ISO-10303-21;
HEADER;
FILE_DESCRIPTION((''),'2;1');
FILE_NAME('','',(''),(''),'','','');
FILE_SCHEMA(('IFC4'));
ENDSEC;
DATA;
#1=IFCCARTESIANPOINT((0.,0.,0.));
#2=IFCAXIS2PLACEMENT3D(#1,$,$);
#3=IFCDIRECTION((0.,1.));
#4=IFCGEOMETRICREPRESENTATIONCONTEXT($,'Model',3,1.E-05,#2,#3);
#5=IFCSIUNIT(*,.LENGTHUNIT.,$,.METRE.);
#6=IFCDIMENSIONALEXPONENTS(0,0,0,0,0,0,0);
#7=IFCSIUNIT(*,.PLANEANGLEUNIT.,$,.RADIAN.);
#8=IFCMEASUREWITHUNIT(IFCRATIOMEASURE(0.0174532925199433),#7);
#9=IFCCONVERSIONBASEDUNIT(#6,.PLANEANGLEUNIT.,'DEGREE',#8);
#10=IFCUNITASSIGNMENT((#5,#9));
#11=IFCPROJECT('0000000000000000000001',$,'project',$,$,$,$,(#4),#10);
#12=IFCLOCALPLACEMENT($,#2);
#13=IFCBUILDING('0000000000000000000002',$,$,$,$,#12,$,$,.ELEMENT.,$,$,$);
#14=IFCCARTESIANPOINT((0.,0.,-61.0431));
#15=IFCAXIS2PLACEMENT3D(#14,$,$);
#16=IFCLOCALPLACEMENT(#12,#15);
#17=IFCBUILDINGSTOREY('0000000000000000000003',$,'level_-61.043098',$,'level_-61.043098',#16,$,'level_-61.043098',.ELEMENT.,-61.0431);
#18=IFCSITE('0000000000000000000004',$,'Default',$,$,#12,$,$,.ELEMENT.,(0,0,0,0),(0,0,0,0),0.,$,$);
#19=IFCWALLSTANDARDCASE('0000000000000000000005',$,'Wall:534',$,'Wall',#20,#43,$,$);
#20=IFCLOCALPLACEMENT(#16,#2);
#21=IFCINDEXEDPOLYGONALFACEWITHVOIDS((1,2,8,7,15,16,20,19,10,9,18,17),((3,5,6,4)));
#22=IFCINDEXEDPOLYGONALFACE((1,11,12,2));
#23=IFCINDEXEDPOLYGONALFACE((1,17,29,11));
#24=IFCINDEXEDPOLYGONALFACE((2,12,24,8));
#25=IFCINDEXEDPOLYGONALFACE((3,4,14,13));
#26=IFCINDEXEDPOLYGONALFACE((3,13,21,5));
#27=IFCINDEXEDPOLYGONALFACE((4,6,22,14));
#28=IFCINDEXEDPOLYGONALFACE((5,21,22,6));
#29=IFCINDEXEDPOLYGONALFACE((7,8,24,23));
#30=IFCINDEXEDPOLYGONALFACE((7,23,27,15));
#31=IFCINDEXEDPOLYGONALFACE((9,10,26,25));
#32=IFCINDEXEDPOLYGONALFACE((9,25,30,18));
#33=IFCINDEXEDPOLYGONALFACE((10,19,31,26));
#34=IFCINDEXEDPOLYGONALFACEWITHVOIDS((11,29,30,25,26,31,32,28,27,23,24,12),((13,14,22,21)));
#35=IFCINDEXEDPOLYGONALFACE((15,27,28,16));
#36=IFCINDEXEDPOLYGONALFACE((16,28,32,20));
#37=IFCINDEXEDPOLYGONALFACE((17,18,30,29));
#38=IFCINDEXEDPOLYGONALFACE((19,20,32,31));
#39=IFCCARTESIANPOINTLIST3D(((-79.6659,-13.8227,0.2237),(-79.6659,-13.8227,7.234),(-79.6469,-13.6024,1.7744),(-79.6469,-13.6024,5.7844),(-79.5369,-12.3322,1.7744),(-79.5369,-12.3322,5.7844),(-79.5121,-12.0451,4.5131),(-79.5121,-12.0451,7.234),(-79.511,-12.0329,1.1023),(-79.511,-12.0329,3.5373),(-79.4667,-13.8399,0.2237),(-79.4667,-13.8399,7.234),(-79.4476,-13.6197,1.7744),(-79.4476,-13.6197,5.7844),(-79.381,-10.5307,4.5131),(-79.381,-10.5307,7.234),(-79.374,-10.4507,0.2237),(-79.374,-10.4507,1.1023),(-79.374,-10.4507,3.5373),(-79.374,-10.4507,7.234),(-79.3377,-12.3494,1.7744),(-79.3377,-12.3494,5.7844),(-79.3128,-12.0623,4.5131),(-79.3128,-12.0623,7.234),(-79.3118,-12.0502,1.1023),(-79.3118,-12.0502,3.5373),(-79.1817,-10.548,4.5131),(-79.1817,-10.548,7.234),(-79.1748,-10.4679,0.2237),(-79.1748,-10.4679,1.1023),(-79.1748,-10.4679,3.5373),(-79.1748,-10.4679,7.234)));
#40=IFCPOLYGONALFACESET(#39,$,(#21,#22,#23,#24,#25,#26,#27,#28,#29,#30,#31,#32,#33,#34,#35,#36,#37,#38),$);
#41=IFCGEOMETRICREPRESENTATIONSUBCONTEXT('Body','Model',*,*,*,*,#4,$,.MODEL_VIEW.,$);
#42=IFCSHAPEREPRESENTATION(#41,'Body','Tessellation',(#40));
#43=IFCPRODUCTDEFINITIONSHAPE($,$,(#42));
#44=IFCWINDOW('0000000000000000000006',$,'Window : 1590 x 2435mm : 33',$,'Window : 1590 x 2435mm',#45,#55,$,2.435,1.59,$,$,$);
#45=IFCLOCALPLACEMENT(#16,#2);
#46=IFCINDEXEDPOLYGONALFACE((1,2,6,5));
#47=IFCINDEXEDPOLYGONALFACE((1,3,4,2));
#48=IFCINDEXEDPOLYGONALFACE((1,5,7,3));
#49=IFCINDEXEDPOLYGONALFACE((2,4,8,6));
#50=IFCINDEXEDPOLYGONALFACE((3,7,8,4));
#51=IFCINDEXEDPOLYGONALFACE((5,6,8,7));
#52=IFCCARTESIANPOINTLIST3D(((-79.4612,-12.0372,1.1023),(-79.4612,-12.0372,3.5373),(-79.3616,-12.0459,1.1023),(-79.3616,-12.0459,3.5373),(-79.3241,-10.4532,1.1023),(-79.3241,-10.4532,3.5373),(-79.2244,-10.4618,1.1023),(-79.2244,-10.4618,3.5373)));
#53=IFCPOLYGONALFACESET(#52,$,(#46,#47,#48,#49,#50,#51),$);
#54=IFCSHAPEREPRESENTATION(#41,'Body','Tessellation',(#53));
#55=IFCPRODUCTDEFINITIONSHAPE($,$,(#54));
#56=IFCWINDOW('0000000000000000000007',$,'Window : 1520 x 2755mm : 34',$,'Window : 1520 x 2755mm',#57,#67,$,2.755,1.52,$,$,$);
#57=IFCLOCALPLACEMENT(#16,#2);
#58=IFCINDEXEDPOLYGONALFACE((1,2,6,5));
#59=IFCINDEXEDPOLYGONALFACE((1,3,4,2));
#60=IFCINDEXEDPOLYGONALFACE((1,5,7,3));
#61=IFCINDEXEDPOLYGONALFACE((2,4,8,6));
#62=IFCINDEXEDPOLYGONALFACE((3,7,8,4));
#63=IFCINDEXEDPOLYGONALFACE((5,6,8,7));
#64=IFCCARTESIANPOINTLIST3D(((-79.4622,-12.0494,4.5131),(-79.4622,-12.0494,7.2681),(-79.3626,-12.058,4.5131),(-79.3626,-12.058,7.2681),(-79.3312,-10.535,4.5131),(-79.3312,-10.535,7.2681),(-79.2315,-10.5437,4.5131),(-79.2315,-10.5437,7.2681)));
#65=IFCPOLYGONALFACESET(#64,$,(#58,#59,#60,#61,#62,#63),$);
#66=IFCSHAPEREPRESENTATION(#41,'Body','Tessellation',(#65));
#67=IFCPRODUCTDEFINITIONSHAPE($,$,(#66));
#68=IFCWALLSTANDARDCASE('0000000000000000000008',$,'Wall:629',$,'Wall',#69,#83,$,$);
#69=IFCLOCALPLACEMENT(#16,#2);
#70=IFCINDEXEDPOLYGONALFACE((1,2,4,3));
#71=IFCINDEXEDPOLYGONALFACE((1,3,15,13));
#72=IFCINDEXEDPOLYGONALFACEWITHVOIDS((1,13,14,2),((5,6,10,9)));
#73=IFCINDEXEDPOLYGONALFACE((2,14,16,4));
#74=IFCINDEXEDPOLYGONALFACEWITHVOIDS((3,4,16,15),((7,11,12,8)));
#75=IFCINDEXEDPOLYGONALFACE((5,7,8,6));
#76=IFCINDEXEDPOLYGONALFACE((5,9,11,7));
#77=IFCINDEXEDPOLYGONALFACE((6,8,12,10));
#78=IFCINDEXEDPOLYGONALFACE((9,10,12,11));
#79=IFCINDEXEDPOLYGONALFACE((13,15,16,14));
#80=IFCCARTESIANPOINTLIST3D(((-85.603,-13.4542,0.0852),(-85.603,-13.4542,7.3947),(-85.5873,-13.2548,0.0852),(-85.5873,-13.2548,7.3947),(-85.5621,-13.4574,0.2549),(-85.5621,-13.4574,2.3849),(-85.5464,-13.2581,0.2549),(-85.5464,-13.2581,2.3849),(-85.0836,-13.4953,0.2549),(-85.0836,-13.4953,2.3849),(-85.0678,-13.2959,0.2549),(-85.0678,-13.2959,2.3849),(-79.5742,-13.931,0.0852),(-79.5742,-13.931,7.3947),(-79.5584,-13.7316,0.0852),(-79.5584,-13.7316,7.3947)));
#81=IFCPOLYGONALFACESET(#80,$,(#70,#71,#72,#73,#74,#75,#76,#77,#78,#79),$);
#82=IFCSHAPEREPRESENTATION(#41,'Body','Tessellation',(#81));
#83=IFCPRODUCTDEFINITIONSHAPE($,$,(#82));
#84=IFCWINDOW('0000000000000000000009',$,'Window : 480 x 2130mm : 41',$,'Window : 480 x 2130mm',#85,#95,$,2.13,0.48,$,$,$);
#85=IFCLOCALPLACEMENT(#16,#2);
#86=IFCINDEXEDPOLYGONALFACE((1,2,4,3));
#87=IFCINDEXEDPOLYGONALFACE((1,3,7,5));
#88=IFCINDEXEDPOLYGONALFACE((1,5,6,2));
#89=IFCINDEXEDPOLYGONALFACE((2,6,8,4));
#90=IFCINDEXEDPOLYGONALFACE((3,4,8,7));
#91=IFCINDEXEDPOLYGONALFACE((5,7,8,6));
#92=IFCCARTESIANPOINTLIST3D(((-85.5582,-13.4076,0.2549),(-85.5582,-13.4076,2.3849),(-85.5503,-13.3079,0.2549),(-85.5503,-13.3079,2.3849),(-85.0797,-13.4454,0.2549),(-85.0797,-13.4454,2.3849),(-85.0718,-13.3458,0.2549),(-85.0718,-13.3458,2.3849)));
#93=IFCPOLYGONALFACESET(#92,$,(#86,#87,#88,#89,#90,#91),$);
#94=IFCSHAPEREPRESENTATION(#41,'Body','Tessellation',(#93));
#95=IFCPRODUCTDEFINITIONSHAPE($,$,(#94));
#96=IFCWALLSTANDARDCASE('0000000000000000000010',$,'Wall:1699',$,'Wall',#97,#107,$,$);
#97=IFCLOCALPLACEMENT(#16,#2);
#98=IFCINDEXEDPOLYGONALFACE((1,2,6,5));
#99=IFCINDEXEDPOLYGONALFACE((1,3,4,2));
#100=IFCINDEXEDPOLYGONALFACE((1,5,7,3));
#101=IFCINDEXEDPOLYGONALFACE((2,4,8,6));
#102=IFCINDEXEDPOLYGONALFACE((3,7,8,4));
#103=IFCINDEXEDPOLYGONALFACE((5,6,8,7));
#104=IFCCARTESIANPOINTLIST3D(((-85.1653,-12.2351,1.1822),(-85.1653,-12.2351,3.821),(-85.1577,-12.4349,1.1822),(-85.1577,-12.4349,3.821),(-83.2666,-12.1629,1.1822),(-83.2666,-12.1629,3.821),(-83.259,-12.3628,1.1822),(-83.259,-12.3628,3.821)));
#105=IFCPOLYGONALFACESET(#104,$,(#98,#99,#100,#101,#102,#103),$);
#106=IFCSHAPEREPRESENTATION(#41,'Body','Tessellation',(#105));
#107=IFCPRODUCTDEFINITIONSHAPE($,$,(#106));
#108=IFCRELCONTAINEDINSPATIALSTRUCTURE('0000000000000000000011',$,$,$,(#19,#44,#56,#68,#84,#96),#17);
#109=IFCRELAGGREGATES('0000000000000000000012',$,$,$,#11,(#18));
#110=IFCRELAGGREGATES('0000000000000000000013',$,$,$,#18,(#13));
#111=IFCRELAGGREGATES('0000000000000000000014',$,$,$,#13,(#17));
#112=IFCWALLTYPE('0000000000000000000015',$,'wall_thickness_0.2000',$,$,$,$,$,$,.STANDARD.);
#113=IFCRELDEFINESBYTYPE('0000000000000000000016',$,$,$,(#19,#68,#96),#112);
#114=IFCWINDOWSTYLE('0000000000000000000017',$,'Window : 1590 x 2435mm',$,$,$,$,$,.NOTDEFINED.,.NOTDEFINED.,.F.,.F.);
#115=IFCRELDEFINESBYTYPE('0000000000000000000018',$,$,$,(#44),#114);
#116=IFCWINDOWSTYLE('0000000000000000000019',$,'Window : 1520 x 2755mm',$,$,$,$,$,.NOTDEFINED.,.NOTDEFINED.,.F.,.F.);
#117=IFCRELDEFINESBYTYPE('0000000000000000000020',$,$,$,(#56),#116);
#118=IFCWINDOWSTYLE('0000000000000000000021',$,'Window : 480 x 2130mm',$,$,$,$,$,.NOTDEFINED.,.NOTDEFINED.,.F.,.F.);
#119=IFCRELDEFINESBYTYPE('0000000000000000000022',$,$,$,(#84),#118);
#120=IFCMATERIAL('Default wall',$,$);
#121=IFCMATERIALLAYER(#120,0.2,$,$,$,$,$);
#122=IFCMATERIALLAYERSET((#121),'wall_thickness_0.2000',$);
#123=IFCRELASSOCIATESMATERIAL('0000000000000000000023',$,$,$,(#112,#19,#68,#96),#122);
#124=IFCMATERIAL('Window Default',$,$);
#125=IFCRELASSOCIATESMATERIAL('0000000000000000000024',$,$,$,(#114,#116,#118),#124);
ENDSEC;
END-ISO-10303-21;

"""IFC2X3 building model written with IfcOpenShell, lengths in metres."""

from ifc_helpers import new_model, entity, si_unit, converted_unit, direction, frame, frame_2d, origin, origin_2d_with_axis, place, context, subcontext, project, spatial, polyline, rectangle, outline, extrude, source, transform, mapped, material, layer, layer_set, layer_usage, type_object, type_shapes, element, fill, save


model = new_model("IFC2X3")

# Units and contexts
model_context = context("Model", 3, precision=1e-05, world=origin(), true_north=direction((0.0, 1.0)))
body_context = subcontext(model_context, "Body", "Model", "MODEL_VIEW")
ifc_project = project(units=[si_unit("LENGTHUNIT", "METRE"), converted_unit("PLANEANGLEUNIT", "DEGREE", entity("IfcRatioMeasure", 0.0174532925199433), si_unit("PLANEANGLEUNIT", "RADIAN"), dimensions=[0, 0, 0, 0, 0, 0, 0])], contexts=[model_context])

# Site, building, storey
placement_1 = place(None, origin())
site = spatial("IfcSite", under=ifc_project, at=placement_1, Name="Default", CompositionType="ELEMENT", RefLatitude=(0, 0, 0, 0), RefLongitude=(0, 0, 0, 0), RefElevation=0.0)
building = spatial("IfcBuilding", under=site, at=placement_1, CompositionType="ELEMENT")
storey_placement = place(placement_1, frame((0.0, 0.0, -61.0431)))
storey = spatial("IfcBuildingStorey", under=building, at=storey_placement, Name="level_-61.043098", ObjectType="level_-61.043098", LongName="level_-61.043098", CompositionType="ELEMENT", Elevation=-61.0431)

# Wall, openings, windows
ifc_material_1 = material(Name="Default wall")
ifc_layer = layer(ifc_material_1, 0.2)
ifc_layer_set = layer_set([ifc_layer], Name="wall_thickness_0.2000")
ifc_layer_usage = layer_usage(ifc_layer_set, "AXIS2", "POSITIVE", -0.1)
wall_type = type_object("IfcWallType", Name="wall_thickness_0.2000", PredefinedType="STANDARD", material=ifc_layer_set)
ifc_material_2 = material(Name="Window Default")
placement_2 = place(placement_1, frame((0.0, 0.0, -60.8194)))
wall_1_placement = place(placement_2, frame((-79.2744, -10.4593, 0.0), z_axis=(0.0, 0.0, 1.0), x_axis=(-0.08624, -0.996274, 0.0)))
wall_1 = element("IfcWallStandardCase", 1, at=wall_1_placement, inside=storey, type_object=wall_type, material=ifc_layer_usage, Name="Wall:534", ObjectType="Wall", context=body_context, shape_type="SweptSolid", body=[
    extrude(outline(polyline([(3.3846, -0.1), (3.3846, 0.1), (0.0, 0.1), (0.0, -0.1), (3.3846, -0.1)])), origin(), (0.0, 0.0, 1.0), 7.0103),
])
opening_1_placement = place(wall_1_placement, frame((1.8885, -0.1, 1.5507)))
element("IfcOpeningElement", 2, at=opening_1_placement, cuts=wall_1, ObjectType="Opening", context=body_context, shape_type="SweptSolid", body=[
    extrude(rectangle(XDim=1.275, YDim=4.01, at=frame_2d((2.005, 0.6375), x_axis=(0.0, 1.0))), frame((0.0, 0.0, 0.0), z_axis=(0.0, 1.0, 0.0), x_axis=(0.0, 0.0, 1.0)), (0.0, 0.0, 1.0), 0.2),
])
opening_2_placement = place(wall_1_placement, frame((-0.0019, -0.1, 0.8786)))
opening_2 = element("IfcOpeningElement", 3, at=opening_2_placement, cuts=wall_1, ObjectType="Opening", context=body_context, shape_type="SweptSolid", body=[
    extrude(rectangle(XDim=1.59, YDim=2.435, at=frame_2d((1.2175, 0.795), x_axis=(0.0, 1.0))), frame((0.0, 0.0, 0.0), z_axis=(0.0, 1.0, 0.0), x_axis=(0.0, 0.0, 1.0)), (0.0, 0.0, 1.0), 0.2),
])
opening_3_placement = place(wall_1_placement, frame((0.0803, -0.1, 4.2894)))
opening_3 = element("IfcOpeningElement", 4, at=opening_3_placement, cuts=wall_1, ObjectType="Opening", context=body_context, shape_type="SweptSolid", body=[
    extrude(rectangle(XDim=1.52, YDim=2.755, at=frame_2d((1.3775, 0.76), x_axis=(0.0, 1.0))), frame((0.0, 0.0, 0.0), z_axis=(0.0, 1.0, 0.0), x_axis=(0.0, 0.0, 1.0)), (0.0, 0.0, 1.0), 0.2),
])
window_style_1 = type_object("IfcWindowStyle", Name="Window : 1590 x 2435mm", ConstructionType="NOTDEFINED", OperationType="NOTDEFINED", ParameterTakesPrecedence=False, Sizeable=False, material=ifc_material_2)
shared_shape_1 = source(origin(), body_context, "Body", "SweptSolid", [
    extrude(rectangle(XDim=0.1, YDim=1.59, at=origin_2d_with_axis()), frame((0.795, 0.1, 0.0), z_axis=(0.0, 0.0, 1.0), x_axis=(0.0, 1.0, 0.0)), (0.0, 0.0, 1.0), 2.435),
])
type_shapes(window_style_1, [shared_shape_1])
window_1_placement = place(opening_2_placement, origin())
window_1 = element("IfcWindow", 5, at=window_1_placement, inside=storey, type_object=window_style_1, Name="Window : 1590 x 2435mm : 33", ObjectType="Window : 1590 x 2435mm", OverallHeight=2.435, OverallWidth=1.59, context=body_context, shape_type="MappedRepresentation", body=[
    mapped(shared_shape_1, transform((0.0, 0.0, 0.0), scale=1.0)),
])
fill(opening_2, window_1)
window_style_2 = type_object("IfcWindowStyle", Name="Window : 1520 x 2755mm", ConstructionType="NOTDEFINED", OperationType="NOTDEFINED", ParameterTakesPrecedence=False, Sizeable=False, material=ifc_material_2)
shared_shape_2 = source(origin(), body_context, "Body", "SweptSolid", [
    extrude(rectangle(XDim=0.1, YDim=1.52, at=origin_2d_with_axis()), frame((0.76, 0.1, 0.0), z_axis=(0.0, 0.0, 1.0), x_axis=(0.0, 1.0, 0.0)), (0.0, 0.0, 1.0), 2.755),
])
type_shapes(window_style_2, [shared_shape_2])
window_2_placement = place(opening_3_placement, origin())
window_2 = element("IfcWindow", 6, at=window_2_placement, inside=storey, type_object=window_style_2, Name="Window : 1520 x 2755mm : 34", ObjectType="Window : 1520 x 2755mm", OverallHeight=2.755, OverallWidth=1.52, context=body_context, shape_type="MappedRepresentation", body=[
    mapped(shared_shape_2, transform((0.0, 0.0, 0.0), scale=1.0)),
])
fill(opening_3, window_2)

# Wall, opening, window
placement_3 = place(placement_1, frame((0.0, 0.0, -60.9579)))
wall_2_placement = place(placement_3, frame((-79.5663, -13.8313, 0.0), z_axis=(0.0, 0.0, 1.0), x_axis=(-0.996888, 0.078836, 0.0)))
wall_2 = element("IfcWallStandardCase", 7, at=wall_2_placement, inside=storey, type_object=wall_type, material=ifc_layer_usage, Name="Wall:629", ObjectType="Wall", context=body_context, shape_type="SweptSolid", body=[
    extrude(outline(polyline([(6.0477, -0.1), (6.0477, 0.1), (0.0, 0.1), (0.0, -0.1), (6.0477, -0.1)])), origin(), (0.0, 0.0, 1.0), 7.3095),
])
opening_4_placement = place(wall_2_placement, frame((5.5266, -0.1, 0.1697)))
opening_4 = element("IfcOpeningElement", 8, at=opening_4_placement, cuts=wall_2, ObjectType="Opening", context=body_context, shape_type="SweptSolid", body=[
    extrude(rectangle(XDim=0.48, YDim=2.13, at=frame_2d((1.065, 0.24), x_axis=(0.0, 1.0))), frame((0.0, 0.0, 0.0), z_axis=(0.0, 1.0, 0.0), x_axis=(0.0, 0.0, 1.0)), (0.0, 0.0, 1.0), 0.2),
])
window_style_3 = type_object("IfcWindowStyle", Name="Window : 480 x 2130mm", ConstructionType="NOTDEFINED", OperationType="NOTDEFINED", ParameterTakesPrecedence=False, Sizeable=False, material=ifc_material_2)
shared_shape_3 = source(origin(), body_context, "Body", "SweptSolid", [
    extrude(rectangle(XDim=0.1, YDim=0.48, at=origin_2d_with_axis()), frame((0.24, 0.1, 0.0), z_axis=(0.0, 0.0, 1.0), x_axis=(0.0, 1.0, 0.0)), (0.0, 0.0, 1.0), 2.13),
])
type_shapes(window_style_3, [shared_shape_3])
window_3_placement = place(opening_4_placement, origin())
window_3 = element("IfcWindow", 9, at=window_3_placement, inside=storey, type_object=window_style_3, Name="Window : 480 x 2130mm : 41", ObjectType="Window : 480 x 2130mm", OverallHeight=2.13, OverallWidth=0.48, context=body_context, shape_type="MappedRepresentation", body=[
    mapped(shared_shape_3, transform((0.0, 0.0, 0.0), scale=1.0)),
])
fill(opening_4, window_3)

# Wall
placement_4 = place(placement_1, frame((0.0, 0.0, -59.8609)))
wall_3_placement = place(placement_4, frame((-83.2628, -12.2629, 0.0), z_axis=(0.0, 0.0, 1.0), x_axis=(-0.999279, -0.037966, 0.0)))
element("IfcWallStandardCase", 10, at=wall_3_placement, inside=storey, type_object=wall_type, material=ifc_layer_usage, Name="Wall:1699", ObjectType="Wall", context=body_context, shape_type="SweptSolid", body=[
    extrude(outline(polyline([(1.9, -0.1), (1.9, 0.1), (0.0, 0.1), (0.0, -0.1), (1.9, -0.1)])), origin(), (0.0, 0.0, 1.0), 2.6388),
])

save(model, "model.ifc")
